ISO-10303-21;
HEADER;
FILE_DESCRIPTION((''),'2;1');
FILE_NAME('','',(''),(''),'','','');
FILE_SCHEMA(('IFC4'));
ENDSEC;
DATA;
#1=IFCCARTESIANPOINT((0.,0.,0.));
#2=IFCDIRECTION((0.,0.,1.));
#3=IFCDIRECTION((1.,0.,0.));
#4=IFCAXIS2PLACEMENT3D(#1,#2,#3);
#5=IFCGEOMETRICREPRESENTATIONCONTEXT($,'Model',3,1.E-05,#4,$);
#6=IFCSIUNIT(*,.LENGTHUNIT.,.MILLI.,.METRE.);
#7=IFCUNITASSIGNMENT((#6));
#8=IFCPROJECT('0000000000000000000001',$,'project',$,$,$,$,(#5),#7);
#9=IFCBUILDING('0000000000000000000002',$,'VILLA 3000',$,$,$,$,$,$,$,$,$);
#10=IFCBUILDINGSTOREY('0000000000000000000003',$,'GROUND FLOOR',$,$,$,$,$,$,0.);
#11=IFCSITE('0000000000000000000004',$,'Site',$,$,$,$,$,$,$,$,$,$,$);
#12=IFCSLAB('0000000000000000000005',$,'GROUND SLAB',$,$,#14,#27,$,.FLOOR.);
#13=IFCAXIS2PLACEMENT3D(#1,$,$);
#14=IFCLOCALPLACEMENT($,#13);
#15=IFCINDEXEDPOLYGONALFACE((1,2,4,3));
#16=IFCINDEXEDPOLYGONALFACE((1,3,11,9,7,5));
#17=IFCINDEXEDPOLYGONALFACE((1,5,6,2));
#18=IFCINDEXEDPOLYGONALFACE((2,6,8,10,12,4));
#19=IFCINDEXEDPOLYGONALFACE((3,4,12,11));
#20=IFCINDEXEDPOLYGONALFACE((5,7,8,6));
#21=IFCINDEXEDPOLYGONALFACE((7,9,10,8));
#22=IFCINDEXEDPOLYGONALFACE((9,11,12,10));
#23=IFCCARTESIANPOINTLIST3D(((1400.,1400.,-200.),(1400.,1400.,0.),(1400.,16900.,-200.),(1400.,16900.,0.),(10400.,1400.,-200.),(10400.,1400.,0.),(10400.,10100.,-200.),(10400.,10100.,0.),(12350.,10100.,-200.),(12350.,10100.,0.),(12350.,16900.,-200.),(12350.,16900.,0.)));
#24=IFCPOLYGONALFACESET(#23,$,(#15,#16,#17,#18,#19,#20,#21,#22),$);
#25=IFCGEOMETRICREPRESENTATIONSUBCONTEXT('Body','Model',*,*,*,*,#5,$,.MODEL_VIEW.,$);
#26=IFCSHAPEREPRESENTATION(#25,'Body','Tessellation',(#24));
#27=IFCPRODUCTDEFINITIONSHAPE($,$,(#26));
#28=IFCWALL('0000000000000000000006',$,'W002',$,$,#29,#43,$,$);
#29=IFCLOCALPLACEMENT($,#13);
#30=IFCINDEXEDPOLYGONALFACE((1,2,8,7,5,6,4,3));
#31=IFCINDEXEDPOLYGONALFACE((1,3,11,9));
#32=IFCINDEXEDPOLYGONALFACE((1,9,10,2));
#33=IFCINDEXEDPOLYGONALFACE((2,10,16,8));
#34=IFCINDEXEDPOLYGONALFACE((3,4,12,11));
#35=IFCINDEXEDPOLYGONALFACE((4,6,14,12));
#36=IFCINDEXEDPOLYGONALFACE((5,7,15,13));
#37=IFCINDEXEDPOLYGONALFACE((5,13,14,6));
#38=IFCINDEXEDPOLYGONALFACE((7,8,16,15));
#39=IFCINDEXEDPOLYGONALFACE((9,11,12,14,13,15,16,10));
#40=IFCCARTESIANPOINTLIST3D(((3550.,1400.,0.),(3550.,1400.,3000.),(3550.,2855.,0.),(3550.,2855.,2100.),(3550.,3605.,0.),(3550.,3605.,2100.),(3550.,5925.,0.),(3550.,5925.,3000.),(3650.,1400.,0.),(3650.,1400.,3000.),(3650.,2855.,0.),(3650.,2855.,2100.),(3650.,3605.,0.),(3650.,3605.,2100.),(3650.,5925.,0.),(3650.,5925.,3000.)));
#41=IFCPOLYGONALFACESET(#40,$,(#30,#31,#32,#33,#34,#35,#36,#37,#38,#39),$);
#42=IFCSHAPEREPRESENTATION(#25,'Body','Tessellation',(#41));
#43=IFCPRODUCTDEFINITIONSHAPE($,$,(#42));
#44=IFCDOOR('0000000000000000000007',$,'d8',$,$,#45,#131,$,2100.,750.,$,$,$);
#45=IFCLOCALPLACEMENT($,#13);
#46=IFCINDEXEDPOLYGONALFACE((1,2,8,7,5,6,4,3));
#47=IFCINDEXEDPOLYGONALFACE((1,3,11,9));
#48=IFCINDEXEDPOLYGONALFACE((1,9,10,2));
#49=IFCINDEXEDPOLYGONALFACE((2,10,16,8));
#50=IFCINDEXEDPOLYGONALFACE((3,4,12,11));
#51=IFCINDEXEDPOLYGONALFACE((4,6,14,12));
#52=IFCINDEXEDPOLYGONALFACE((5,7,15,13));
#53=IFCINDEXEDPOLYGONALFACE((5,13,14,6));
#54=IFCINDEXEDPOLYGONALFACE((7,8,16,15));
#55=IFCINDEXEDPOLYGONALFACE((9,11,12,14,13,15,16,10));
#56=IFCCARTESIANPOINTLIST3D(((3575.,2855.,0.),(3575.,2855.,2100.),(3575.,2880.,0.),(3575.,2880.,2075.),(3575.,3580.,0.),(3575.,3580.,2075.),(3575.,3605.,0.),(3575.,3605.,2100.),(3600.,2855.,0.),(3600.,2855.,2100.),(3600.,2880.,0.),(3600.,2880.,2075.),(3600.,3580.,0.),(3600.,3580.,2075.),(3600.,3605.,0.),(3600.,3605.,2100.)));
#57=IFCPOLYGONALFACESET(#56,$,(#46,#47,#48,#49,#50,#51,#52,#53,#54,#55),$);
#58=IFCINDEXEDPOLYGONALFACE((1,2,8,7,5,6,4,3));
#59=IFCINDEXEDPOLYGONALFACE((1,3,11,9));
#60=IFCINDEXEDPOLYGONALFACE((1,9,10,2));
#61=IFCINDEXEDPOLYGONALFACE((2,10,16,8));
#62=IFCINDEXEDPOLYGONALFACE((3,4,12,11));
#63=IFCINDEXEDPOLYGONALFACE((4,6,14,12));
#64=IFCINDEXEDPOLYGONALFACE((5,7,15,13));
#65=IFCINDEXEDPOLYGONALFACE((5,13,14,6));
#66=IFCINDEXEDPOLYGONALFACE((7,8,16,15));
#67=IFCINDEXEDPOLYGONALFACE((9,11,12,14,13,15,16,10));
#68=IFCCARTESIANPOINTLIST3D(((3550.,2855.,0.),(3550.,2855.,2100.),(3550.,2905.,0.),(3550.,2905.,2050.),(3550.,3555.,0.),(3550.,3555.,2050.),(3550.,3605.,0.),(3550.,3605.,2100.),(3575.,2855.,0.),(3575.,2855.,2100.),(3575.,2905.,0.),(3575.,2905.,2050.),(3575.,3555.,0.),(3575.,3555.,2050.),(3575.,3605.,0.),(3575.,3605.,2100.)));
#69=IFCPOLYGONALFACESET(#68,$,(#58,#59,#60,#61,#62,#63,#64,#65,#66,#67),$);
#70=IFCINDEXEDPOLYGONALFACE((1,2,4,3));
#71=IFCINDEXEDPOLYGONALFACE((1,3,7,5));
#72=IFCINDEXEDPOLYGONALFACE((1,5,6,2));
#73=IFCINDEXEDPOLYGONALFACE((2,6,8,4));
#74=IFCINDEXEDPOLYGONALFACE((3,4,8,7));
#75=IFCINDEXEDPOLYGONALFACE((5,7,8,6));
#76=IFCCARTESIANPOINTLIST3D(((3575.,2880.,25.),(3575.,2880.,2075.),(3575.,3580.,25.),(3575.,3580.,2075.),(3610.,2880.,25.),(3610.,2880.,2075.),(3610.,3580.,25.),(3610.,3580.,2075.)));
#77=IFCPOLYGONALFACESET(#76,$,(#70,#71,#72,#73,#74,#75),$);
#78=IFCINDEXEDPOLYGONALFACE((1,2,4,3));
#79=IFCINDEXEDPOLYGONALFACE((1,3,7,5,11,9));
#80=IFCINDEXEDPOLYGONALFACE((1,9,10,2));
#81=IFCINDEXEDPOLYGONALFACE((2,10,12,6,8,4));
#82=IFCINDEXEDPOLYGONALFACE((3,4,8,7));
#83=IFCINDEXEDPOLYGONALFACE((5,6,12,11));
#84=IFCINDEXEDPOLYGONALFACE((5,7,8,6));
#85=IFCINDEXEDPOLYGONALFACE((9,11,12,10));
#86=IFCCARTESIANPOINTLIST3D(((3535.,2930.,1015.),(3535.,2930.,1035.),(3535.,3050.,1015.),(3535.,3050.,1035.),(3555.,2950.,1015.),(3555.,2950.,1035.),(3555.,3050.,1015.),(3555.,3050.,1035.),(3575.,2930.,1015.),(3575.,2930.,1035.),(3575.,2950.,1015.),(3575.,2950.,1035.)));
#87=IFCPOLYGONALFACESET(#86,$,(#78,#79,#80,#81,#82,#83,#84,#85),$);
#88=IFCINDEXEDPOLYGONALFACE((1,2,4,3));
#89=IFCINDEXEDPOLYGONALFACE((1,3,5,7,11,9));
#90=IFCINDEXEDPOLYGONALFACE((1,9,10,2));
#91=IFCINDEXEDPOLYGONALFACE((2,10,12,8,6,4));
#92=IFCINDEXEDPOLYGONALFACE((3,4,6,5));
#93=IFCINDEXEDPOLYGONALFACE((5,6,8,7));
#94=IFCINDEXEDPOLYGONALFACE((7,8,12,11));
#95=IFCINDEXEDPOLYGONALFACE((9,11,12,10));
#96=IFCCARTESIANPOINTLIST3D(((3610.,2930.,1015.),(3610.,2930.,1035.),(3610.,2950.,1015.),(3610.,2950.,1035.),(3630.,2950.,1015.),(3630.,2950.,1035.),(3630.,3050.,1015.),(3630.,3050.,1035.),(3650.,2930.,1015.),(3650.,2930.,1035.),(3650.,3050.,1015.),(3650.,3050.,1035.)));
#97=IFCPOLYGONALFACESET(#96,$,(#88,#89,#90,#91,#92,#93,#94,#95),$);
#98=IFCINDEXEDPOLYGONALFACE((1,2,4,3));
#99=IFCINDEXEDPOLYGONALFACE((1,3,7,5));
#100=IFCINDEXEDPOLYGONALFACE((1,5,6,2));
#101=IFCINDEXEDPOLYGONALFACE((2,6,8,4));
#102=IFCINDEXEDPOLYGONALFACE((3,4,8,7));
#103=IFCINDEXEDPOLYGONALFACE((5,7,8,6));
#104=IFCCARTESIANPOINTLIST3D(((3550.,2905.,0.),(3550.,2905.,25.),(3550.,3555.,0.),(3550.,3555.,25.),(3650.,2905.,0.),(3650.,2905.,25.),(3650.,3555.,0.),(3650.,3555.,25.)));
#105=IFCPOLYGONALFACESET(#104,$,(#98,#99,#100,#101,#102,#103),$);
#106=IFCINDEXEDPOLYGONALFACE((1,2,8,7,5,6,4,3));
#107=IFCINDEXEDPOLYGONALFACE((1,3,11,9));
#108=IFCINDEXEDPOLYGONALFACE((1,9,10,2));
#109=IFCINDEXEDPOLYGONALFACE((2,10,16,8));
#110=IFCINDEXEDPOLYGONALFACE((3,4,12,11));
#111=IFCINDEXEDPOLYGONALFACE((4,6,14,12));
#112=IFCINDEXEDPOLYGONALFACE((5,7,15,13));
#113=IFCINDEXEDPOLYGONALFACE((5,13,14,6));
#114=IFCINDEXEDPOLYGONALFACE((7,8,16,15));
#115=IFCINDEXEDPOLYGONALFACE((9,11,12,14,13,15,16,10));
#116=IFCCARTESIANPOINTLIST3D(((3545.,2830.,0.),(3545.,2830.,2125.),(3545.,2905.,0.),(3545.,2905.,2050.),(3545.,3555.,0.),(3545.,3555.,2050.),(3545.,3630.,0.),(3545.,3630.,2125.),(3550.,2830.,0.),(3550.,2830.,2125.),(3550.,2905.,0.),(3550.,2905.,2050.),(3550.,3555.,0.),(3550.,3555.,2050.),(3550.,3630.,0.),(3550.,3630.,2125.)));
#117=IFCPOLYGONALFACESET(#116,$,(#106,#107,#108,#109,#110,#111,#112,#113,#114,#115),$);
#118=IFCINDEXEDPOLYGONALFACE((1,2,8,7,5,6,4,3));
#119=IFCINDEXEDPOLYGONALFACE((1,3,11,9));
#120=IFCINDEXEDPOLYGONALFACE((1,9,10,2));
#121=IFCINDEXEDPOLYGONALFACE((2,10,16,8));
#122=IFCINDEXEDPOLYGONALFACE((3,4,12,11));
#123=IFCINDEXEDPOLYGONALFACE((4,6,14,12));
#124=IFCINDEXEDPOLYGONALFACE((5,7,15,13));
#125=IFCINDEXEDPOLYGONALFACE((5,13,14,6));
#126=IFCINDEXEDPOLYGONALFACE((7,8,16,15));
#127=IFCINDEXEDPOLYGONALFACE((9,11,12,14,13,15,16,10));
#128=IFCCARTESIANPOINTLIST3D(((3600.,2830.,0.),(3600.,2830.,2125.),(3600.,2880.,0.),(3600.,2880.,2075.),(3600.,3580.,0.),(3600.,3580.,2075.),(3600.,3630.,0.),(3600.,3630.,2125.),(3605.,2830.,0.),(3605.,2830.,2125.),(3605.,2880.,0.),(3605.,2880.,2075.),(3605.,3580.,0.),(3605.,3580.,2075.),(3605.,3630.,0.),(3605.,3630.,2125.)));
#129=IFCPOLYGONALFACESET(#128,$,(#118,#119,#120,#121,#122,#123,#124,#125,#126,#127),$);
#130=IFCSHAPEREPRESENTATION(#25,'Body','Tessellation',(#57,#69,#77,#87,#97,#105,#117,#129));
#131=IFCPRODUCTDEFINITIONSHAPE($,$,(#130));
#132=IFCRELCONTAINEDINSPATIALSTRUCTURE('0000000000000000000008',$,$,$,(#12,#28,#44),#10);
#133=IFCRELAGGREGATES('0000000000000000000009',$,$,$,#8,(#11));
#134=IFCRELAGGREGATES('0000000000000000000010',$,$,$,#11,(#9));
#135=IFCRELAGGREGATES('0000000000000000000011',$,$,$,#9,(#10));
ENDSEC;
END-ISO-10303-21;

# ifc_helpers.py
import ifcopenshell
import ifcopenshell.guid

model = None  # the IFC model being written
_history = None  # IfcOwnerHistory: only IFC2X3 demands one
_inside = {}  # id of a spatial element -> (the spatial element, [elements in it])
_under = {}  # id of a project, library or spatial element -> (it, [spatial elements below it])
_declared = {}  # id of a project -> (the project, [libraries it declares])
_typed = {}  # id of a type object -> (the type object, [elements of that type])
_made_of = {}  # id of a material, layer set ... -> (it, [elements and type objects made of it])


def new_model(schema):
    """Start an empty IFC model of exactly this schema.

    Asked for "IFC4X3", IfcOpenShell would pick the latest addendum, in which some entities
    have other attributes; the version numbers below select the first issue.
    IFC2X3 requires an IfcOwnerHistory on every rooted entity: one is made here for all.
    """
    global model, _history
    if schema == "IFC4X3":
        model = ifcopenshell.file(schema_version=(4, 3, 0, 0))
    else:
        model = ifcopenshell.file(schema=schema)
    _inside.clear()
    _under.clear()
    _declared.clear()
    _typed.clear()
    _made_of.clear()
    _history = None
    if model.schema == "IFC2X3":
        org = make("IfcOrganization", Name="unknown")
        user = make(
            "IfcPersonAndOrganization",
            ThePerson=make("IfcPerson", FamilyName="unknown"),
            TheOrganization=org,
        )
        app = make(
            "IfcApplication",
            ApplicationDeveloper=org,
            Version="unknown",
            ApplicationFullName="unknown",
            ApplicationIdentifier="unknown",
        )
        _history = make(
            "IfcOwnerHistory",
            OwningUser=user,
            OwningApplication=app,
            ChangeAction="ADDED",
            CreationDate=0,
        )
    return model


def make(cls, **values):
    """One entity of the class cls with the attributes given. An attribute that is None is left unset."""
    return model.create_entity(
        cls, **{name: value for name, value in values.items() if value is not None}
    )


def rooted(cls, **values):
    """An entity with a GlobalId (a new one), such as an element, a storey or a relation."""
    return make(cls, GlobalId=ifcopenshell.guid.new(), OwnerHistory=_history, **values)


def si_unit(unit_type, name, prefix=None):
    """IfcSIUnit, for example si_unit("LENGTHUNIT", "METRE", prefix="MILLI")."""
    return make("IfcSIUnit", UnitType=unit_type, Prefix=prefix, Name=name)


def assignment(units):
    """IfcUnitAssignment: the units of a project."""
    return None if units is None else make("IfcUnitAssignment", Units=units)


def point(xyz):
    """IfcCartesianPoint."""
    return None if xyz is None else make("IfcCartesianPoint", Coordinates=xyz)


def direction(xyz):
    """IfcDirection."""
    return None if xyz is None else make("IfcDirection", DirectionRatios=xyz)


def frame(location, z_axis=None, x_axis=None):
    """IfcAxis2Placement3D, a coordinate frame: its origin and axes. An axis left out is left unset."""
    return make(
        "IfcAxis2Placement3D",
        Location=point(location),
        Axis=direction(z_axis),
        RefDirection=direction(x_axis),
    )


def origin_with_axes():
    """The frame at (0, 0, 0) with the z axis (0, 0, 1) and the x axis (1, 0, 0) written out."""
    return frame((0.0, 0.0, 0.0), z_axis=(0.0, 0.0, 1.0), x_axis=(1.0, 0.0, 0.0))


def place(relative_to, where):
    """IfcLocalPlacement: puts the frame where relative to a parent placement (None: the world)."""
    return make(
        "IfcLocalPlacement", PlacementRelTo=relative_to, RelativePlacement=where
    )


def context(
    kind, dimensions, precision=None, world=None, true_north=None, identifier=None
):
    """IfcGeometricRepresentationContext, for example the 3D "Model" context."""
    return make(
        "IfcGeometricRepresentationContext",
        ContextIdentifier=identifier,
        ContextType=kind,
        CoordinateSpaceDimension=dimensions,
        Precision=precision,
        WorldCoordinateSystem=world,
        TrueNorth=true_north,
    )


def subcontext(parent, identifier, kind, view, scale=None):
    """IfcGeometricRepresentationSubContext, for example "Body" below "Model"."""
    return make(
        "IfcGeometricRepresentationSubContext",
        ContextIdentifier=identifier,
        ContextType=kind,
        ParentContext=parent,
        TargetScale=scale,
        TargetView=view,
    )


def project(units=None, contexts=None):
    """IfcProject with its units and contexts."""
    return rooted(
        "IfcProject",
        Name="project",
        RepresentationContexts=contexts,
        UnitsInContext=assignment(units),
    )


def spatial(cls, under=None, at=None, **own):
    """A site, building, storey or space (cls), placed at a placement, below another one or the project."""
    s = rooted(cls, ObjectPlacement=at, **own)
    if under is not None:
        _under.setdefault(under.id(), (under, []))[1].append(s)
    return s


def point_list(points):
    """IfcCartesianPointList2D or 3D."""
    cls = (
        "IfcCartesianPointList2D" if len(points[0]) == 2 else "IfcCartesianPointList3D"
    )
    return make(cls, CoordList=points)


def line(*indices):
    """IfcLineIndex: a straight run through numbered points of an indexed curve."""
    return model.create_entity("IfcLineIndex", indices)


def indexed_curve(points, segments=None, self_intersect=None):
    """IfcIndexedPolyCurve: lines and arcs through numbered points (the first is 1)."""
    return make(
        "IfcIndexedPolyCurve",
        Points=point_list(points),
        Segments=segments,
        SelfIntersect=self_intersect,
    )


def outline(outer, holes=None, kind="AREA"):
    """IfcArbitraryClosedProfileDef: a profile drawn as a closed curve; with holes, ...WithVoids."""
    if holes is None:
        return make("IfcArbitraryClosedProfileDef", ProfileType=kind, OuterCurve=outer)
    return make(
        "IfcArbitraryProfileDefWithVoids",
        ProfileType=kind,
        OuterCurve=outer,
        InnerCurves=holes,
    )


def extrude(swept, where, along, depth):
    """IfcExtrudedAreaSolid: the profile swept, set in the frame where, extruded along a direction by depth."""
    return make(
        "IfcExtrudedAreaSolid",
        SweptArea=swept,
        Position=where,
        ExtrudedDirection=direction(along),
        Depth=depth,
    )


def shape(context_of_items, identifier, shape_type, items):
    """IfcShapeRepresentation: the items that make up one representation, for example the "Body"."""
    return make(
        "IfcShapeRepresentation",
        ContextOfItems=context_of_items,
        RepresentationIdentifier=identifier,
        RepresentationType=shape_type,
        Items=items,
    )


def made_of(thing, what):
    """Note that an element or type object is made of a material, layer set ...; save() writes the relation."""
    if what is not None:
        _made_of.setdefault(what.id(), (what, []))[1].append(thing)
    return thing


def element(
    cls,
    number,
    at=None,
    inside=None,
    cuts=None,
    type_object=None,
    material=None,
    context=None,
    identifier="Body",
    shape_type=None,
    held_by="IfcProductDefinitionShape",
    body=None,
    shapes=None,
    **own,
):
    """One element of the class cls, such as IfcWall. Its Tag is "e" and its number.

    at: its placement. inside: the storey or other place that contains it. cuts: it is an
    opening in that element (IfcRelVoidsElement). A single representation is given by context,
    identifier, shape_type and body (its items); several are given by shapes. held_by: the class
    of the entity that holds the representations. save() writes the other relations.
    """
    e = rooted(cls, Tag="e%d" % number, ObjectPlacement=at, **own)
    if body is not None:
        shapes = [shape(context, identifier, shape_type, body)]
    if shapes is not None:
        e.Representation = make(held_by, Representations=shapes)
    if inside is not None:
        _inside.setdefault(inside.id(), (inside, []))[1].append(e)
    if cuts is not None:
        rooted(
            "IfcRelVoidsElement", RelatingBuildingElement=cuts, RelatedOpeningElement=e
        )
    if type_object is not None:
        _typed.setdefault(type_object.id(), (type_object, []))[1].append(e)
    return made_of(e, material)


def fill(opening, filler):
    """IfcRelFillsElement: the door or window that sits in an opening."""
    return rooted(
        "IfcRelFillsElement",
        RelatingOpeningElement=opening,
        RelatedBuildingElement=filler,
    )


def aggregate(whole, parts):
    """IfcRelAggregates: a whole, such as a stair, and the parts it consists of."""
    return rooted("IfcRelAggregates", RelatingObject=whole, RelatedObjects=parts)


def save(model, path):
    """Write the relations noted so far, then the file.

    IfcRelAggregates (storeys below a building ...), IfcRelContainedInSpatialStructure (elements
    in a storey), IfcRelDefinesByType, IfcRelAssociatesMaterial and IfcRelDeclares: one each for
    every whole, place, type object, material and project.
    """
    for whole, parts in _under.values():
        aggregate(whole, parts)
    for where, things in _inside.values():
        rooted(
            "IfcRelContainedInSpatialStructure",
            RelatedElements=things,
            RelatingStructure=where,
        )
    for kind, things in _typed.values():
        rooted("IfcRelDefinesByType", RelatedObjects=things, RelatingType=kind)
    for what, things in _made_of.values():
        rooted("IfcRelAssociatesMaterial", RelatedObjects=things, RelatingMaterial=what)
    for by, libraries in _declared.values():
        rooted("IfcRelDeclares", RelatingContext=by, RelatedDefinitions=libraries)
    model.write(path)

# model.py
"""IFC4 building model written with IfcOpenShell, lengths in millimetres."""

from ifc_helpers import new_model, si_unit, frame, origin_with_axes, place, context, subcontext, project, spatial, line, indexed_curve, outline, extrude, element, fill, save


model = new_model("IFC4")

# Units and contexts
model_context = context("Model", 3, precision=1e-05, world=origin_with_axes())
body_context = subcontext(model_context, "Body", "Model", "MODEL_VIEW")
ifc_project = project(units=[si_unit("LENGTHUNIT", "METRE", prefix="MILLI")], contexts=[model_context])

# Site, building, storey
site = spatial("IfcSite", under=ifc_project, Name="Site")
building = spatial("IfcBuilding", under=site, Name="VILLA 3000")
storey = spatial("IfcBuildingStorey", under=building, Name="GROUND FLOOR", Elevation=0.0)

# Slab
slab_placement = place(None, frame((0.0, 0.0, -200.0), z_axis=(0.0, 0.0, 1.0), x_axis=(1.0, 0.0, 0.0)))
element("IfcSlab", 1, at=slab_placement, inside=storey, Name="GROUND SLAB", PredefinedType="FLOOR", context=body_context, shape_type="SweptSolid", body=[
    extrude(outline(indexed_curve([(1400.0, 16900.0), (1400.0, 1400.0), (10400.0, 1400.0), (10400.0, 10100.0), (12350.0, 10100.0), (12350.0, 16900.0)])), None, (0.0, 0.0, 1.0), 200.0),
])

# Wall, opening, door
wall_1_placement = place(None, frame((3600.0, 5925.0, 0.0), z_axis=(0.0, 0.0, 1.0), x_axis=(0.0, -1.0, 0.0)))
wall_1 = element("IfcWall", 2, at=wall_1_placement, inside=storey, Name="W002", context=body_context, shape_type="SweptSolid", body=[
    extrude(outline(indexed_curve([(0.0, 0.0), (0.0, 100.0), (4525.0, 100.0), (4525.0, 0.0), (0.0, 0.0)], self_intersect=False)), frame((0.0, -50.0, 0.0), z_axis=(0.0, 0.0, 1.0), x_axis=(1.0, 0.0, 0.0)), (0.0, 0.0, 1.0), 3000.0),
])
opening_1_placement = place(wall_1_placement, frame((2320.0, 0.0, 0.0), z_axis=(0.0, 0.0, 1.0), x_axis=(1.0, 0.0, 0.0)))
opening_1 = element("IfcOpeningElement", 3, at=opening_1_placement, cuts=wall_1, context=body_context, shape_type="SweptSolid", body=[
    extrude(outline(indexed_curve([(0.0, 0.0), (0.0, 200.0), (750.0, 200.0), (750.0, 0.0), (0.0, 0.0)], self_intersect=False)), frame((0.0, -100.0, 0.0), z_axis=(0.0, 0.0, 1.0), x_axis=(1.0, 0.0, 0.0)), (0.0, 0.0, 1.0), 2100.0),
])
door_1_placement = place(None, frame((3550.0, 3605.0, 0.0), z_axis=(0.0, 0.0, 1.0), x_axis=(0.0, -1.0, 0.0)))
door_1 = element("IfcDoor", 4, at=door_1_placement, inside=storey, Name="d8", OverallHeight=2100.0, OverallWidth=750.0, context=body_context, shape_type="SweptSolid", body=[
    extrude(outline(indexed_curve([(0.0, 0.0), (0.0, 2100.0), (750.0, 2100.0), (750.0, 0.0), (725.0, 0.0), (725.0, 2075.0), (25.0, 2075.0), (25.0, 0.0)], segments=[line(1, 2, 3, 4, 5, 6, 7, 8, 1)])), frame((0.0, 25.0, 0.0), z_axis=(0.0, -1.0, 0.0), x_axis=(1.0, 0.0, 0.0)), (0.0, 0.0, -1.0), 25.0),
    extrude(outline(indexed_curve([(0.0, 0.0), (0.0, 2100.0), (750.0, 2100.0), (750.0, 0.0), (700.0, 0.0), (700.0, 2050.0), (50.0, 2050.0), (50.0, 0.0)], segments=[line(1, 2, 3, 4, 5, 6, 7, 8, 1)])), frame((0.0, 0.0, 0.0), z_axis=(0.0, -1.0, 0.0), x_axis=(1.0, 0.0, 0.0)), (0.0, 0.0, -1.0), 25.0),
    extrude(outline(indexed_curve([(0.0, 0.0), (700.0, 0.0), (700.0, 35.0), (0.0, 35.0)], segments=[line(1, 2, 3, 4, 1)])), frame((25.0, 25.0, 25.0), z_axis=(0.0, 0.0, 1.0), x_axis=(1.0, 0.0, 0.0)), (0.0, 0.0, 1.0), 2050.0),
    extrude(outline(indexed_curve([(0.0, 0.0), (0.0, -40.0), (-120.0, -40.0), (-120.0, -20.0), (-20.0, -20.0), (-20.0, 0.0)], segments=[line(1, 2, 3, 4, 5, 6, 1)])), frame((675.0, 25.0, 1015.0), z_axis=(0.0, 0.0, 1.0), x_axis=(1.0, 0.0, 0.0)), (0.0, 0.0, 1.0), 20.0),
    extrude(outline(indexed_curve([(0.0, 0.0), (0.0, 40.0), (-120.0, 40.0), (-120.0, 20.0), (-20.0, 20.0), (-20.0, 0.0)], segments=[line(1, 2, 3, 4, 5, 6, 1)])), frame((675.0, 60.0, 1015.0), z_axis=(0.0, 0.0, 1.0), x_axis=(1.0, 0.0, 0.0)), (0.0, 0.0, 1.0), 20.0),
    extrude(outline(indexed_curve([(0.0, 0.0), (650.0, 0.0), (650.0, 100.0), (0.0, 100.0)], segments=[line(1, 2, 3, 4, 1)])), frame((50.0, 0.0, 0.0), z_axis=(0.0, 0.0, 1.0), x_axis=(1.0, 0.0, 0.0)), (0.0, 0.0, 1.0), 25.0),
    extrude(outline(indexed_curve([(0.0, 0.0), (0.0, 2125.0), (800.0, 2125.0), (800.0, 0.0), (725.0, 0.0), (725.0, 2050.0), (75.0, 2050.0), (75.0, 0.0)], segments=[line(1, 2, 3, 4, 5, 6, 7, 8, 1)])), frame((-25.0, -5.0, 0.0), z_axis=(0.0, -1.0, 0.0), x_axis=(1.0, 0.0, 0.0)), (0.0, 0.0, -1.0), 5.0),
    extrude(outline(indexed_curve([(0.0, 0.0), (0.0, 2125.0), (800.0, 2125.0), (800.0, 0.0), (750.0, 0.0), (750.0, 2075.0), (50.0, 2075.0), (50.0, 0.0)], segments=[line(1, 2, 3, 4, 5, 6, 7, 8, 1)])), frame((-25.0, 50.0, 0.0), z_axis=(0.0, -1.0, 0.0), x_axis=(1.0, 0.0, 0.0)), (0.0, 0.0, -1.0), 5.0),
])
fill(opening_1, door_1)

save(model, "model.ifc")
